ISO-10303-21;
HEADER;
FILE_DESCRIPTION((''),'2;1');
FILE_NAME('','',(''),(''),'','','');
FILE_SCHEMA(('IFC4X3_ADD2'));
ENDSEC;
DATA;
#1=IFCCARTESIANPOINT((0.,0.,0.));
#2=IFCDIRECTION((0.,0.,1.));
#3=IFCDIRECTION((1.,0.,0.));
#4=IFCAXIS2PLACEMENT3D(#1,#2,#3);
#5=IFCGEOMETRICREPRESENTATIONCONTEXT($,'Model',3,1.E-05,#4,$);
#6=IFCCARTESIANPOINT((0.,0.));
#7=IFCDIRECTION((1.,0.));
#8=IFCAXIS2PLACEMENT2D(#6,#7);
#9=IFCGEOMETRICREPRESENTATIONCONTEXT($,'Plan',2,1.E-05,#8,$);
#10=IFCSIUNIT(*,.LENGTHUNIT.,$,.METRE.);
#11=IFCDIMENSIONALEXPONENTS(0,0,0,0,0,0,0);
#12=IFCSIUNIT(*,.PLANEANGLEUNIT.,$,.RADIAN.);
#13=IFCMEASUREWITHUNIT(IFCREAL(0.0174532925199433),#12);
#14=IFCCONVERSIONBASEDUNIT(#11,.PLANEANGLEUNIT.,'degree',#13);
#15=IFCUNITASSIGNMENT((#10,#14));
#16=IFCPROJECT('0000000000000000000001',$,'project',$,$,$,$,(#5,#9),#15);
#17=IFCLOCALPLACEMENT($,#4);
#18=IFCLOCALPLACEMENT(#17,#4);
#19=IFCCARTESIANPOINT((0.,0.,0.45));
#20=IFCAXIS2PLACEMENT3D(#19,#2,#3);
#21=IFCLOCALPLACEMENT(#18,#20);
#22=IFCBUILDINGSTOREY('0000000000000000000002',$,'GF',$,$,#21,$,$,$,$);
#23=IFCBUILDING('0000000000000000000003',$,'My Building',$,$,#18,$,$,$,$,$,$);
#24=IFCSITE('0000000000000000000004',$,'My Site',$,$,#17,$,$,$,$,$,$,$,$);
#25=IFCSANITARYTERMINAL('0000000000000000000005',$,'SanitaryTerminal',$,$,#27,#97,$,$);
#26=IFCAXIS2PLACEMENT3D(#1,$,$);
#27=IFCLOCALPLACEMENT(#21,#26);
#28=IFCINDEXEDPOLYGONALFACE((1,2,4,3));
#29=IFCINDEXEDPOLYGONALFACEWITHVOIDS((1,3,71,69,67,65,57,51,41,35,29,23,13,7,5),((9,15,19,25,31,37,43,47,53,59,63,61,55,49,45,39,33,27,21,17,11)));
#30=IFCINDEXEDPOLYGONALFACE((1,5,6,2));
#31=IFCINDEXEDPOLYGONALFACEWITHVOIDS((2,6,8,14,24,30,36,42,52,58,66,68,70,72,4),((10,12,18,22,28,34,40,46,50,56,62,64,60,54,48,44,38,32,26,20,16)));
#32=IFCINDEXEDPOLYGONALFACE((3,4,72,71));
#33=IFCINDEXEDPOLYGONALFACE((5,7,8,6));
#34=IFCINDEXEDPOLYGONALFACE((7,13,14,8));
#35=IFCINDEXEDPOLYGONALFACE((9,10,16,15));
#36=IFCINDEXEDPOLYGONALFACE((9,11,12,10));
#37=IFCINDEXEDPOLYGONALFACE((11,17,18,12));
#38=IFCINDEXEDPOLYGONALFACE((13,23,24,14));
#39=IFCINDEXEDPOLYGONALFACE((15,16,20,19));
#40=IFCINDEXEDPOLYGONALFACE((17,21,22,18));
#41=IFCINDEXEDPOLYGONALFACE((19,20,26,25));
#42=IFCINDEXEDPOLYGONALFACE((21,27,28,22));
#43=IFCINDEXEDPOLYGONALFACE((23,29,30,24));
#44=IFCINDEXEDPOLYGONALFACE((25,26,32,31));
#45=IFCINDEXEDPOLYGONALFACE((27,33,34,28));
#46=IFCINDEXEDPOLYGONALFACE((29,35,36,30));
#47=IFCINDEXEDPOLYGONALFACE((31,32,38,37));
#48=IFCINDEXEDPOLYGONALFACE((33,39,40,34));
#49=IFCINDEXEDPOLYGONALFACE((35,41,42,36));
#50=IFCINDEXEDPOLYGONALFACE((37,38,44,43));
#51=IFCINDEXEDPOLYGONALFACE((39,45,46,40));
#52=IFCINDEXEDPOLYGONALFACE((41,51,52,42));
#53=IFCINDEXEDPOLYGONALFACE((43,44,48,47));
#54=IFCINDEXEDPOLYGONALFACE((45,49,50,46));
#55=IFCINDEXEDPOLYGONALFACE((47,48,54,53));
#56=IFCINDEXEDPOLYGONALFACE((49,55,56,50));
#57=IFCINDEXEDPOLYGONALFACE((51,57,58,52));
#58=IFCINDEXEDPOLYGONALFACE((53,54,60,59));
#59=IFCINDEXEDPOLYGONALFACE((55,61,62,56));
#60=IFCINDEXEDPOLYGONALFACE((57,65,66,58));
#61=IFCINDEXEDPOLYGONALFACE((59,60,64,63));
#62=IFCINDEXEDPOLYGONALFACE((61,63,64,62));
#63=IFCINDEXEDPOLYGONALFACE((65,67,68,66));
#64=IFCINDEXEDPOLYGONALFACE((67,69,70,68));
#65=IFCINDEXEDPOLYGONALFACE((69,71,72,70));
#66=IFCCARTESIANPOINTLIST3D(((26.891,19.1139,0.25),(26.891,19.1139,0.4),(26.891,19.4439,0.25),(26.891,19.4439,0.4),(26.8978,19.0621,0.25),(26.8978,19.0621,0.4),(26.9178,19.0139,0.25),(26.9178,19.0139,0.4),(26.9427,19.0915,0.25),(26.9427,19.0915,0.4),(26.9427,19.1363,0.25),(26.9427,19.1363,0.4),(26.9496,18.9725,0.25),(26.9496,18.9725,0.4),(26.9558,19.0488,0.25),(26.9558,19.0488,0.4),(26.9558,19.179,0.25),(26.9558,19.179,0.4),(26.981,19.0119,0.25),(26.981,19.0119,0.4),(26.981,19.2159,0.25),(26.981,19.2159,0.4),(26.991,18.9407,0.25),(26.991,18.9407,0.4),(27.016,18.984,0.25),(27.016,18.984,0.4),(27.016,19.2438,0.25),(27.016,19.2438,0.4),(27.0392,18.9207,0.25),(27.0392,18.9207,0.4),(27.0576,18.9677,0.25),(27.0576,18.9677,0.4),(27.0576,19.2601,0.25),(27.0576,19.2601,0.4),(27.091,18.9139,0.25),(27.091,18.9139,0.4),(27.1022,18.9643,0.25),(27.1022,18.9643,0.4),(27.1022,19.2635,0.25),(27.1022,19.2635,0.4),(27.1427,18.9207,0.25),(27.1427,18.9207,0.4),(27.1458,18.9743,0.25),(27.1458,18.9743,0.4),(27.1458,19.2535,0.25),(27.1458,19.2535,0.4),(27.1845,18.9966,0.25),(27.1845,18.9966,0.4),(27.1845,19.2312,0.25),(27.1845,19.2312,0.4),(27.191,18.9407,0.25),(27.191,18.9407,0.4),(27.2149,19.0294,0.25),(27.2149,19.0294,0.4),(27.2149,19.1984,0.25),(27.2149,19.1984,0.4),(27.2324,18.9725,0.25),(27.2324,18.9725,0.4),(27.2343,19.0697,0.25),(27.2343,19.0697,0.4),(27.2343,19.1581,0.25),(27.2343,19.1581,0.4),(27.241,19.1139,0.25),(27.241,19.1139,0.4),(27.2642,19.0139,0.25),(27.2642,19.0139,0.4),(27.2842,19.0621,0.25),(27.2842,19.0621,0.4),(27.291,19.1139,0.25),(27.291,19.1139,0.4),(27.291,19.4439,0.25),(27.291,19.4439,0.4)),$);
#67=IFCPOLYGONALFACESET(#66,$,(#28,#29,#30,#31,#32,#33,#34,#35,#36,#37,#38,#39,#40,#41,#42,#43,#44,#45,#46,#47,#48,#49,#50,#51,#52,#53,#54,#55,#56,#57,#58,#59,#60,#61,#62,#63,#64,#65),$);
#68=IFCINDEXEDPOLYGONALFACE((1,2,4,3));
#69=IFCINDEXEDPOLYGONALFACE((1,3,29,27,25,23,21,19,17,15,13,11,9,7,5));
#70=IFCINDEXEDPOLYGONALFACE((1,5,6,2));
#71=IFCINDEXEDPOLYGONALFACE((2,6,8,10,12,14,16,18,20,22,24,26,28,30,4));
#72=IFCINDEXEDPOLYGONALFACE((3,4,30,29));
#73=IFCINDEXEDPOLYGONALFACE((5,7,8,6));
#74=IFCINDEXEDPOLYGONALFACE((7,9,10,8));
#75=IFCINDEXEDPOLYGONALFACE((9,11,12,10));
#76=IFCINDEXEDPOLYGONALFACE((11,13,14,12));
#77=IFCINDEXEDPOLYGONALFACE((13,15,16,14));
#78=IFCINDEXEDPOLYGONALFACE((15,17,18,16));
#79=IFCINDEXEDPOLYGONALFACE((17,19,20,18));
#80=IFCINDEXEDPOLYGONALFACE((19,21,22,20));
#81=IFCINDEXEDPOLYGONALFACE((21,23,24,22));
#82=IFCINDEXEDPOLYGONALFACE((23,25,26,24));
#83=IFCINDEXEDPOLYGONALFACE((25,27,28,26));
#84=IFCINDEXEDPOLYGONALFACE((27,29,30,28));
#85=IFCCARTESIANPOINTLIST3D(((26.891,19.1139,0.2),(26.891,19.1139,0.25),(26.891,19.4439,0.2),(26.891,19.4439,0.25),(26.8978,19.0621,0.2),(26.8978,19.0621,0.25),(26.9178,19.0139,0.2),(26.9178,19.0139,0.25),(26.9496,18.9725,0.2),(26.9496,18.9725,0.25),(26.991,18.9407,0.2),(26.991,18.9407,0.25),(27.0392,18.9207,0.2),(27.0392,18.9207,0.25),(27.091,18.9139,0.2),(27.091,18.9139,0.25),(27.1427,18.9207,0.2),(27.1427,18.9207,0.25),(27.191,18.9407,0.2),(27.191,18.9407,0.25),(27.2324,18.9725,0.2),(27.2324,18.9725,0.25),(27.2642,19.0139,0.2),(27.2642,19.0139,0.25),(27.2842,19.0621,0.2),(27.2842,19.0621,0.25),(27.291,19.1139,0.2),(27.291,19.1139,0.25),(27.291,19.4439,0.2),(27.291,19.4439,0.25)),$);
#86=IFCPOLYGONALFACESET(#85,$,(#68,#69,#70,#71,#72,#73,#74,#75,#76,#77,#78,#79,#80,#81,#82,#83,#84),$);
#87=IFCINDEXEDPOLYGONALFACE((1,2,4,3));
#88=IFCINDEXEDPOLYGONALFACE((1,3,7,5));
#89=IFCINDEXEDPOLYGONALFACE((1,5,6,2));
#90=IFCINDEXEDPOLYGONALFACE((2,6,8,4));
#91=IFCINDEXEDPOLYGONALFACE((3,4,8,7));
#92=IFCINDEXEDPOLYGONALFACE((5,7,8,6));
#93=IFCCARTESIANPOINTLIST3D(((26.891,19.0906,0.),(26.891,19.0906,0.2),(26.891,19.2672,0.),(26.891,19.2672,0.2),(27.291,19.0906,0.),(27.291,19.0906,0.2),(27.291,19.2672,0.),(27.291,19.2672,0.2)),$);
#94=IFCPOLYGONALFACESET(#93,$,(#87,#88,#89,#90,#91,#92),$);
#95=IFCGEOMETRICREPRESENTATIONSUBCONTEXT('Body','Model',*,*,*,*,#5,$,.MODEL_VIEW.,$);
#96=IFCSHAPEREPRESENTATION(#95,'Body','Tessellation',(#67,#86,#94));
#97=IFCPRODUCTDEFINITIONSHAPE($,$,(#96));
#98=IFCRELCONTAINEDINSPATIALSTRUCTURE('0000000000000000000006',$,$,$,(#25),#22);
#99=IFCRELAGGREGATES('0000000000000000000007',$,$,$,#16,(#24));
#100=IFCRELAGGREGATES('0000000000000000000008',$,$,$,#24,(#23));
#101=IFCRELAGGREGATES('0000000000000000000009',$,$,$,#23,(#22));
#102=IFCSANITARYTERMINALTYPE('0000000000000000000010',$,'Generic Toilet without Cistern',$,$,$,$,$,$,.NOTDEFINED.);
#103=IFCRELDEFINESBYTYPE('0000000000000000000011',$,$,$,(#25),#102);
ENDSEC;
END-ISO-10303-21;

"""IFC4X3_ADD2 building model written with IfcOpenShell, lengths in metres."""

from ifc_helpers import new_model, entity, si_unit, converted_unit, frame, frame_2d, origin_with_axes, origin_2d_with_axis, place, context, subcontext, project, spatial, line, arc, indexed_curve, circle_curve, outline, extrude, shape, source, transform, mapped, type_object, type_shapes, element, save


model = new_model("IFC4X3_ADD2")

# Units and contexts
model_context = context("Model", 3, precision=1e-05, world=origin_with_axes())
plan_context = context("Plan", 2, precision=1e-05, world=origin_2d_with_axis())
body_context_1 = subcontext(model_context, "Body", "Model", "MODEL_VIEW")
body_context_2 = subcontext(plan_context, "Body", "Plan", "PLAN_VIEW")
ifc_project = project(units=[si_unit("LENGTHUNIT", "METRE"), converted_unit("PLANEANGLEUNIT", "degree", entity("IfcReal", 0.0174532925199433), si_unit("PLANEANGLEUNIT", "RADIAN"), dimensions=[0, 0, 0, 0, 0, 0, 0])], contexts=[model_context, plan_context])

# Site, building, storey
site_placement = place(None, origin_with_axes())
site = spatial("IfcSite", under=ifc_project, at=site_placement, Name="My Site")
building_placement = place(site_placement, origin_with_axes())
building = spatial("IfcBuilding", under=site, at=building_placement, Name="My Building")
storey_placement = place(building_placement, frame((0.0, 0.0, 0.45), z_axis=(0.0, 0.0, 1.0), x_axis=(1.0, 0.0, 0.0)))
storey = spatial("IfcBuildingStorey", under=building, at=storey_placement, Name="GF")

# Sanitary terminal
sanitary_terminal_type_1 = type_object("IfcSanitaryTerminalType", Name="Generic Toilet without Cistern", PredefinedType="NOTDEFINED")
shared_shape_1 = source(origin_with_axes(), body_context_1, "Body", "SweptSolid", [
    extrude(outline(indexed_curve([(-0.2, 0.0), (0.2, 0.0), (0.2, -0.33), (0.1414, -0.4714), (0.0, -0.53), (-0.1414, -0.4714), (-0.2, -0.33)], segments=[line(1, 2), line(2, 3), arc(3, 4, 5), arc(5, 6, 7), line(7, 1)]), holes=[circle_curve(frame_2d((0.0, -0.33)), 0.15)]), frame((0.0, 0.0, 0.25), z_axis=(0.0, 0.0, 1.0), x_axis=(1.0, 0.0, 0.0)), (0.0, 0.0, 1.0), 0.15),
    extrude(outline(indexed_curve([(-0.2, 0.0), (0.2, 0.0), (0.2, -0.33), (0.1414, -0.4714), (0.0, -0.53), (-0.1414, -0.4714), (-0.2, -0.33)], segments=[line(1, 2), line(2, 3), arc(3, 4, 5), arc(5, 6, 7), line(7, 1)])), frame((0.0, 0.0, 0.2), z_axis=(0.0, 0.0, 1.0), x_axis=(1.0, 0.0, 0.0)), (0.0, 0.0, 1.0), 0.05),
    extrude(outline(indexed_curve([(-0.2, -0.1767), (0.2, -0.1767), (0.2, -0.3533), (-0.2, -0.3533)], segments=[line(1, 2, 3, 4, 1)])), origin_with_axes(), (0.0, 0.0, 1.0), 0.2),
])
shared_shape_2 = source(origin_with_axes(), body_context_2, "Body", "Annotation2D", [
    entity("IfcGeometricCurveSet", [entity("IfcIndexedPolyCurve", entity("IfcCartesianPointList2D", [[-0.1068, -0.124], [-0.0957, -0.1129], [-0.0804, -0.1088], [0.0804, -0.1088], [0.0957, -0.1129], [0.1068, -0.124], [0.1109, -0.1393], [0.1109, -0.3476], [0.1025, -0.3926], [0.0784, -0.4308], [0.0424, -0.4563], [0.0, -0.4652], [-0.0424, -0.4563], [-0.0784, -0.4308], [-0.1025, -0.3926], [-0.1109, -0.3476], [-0.1109, -0.1393]]), [entity("IfcLineIndex", [1, 2, 3, 4, 5, 6, 7, 8, 9, 10, 11, 12, 13, 14, 15, 16, 17, 1])]), entity("IfcIndexedPolyCurve", entity("IfcCartesianPointList2D", [[-0.1962, -0.2314], [-0.1848, -0.301], [-0.1764, -0.3339], [-0.1663, -0.3651], [-0.1546, -0.3944], [-0.1414, -0.4213], [-0.1269, -0.4458], [-0.1111, -0.4675], [-0.0943, -0.4862], [-0.0765, -0.5018], [-0.0581, -0.514], [-0.039, -0.5229], [-0.0196, -0.5282], [0.0, -0.53], [0.0196, -0.5282], [0.039, -0.5229], [0.0581, -0.514], [0.0765, -0.5018], [0.0943, -0.4862], [0.1111, -0.4675], [0.1269, -0.4458], [0.1414, -0.4213], [0.1546, -0.3944], [0.1663, -0.3651], [0.1764, -0.3339], [0.1848, -0.301], [0.1962, -0.2314], [0.2, -0.159], [0.1872, 0.0], [-0.1872, 0.0], [-0.2, -0.159]]), [entity("IfcLineIndex", [1, 2, 3, 4, 5, 6, 7, 8, 9, 10, 11, 12, 13, 14, 15, 16, 17, 18, 19, 20, 21, 22, 23, 24, 25, 26, 27, 28, 29, 30, 31, 1])])]),
])
type_shapes(sanitary_terminal_type_1, [shared_shape_1, shared_shape_2])
sanitary_terminal_1_placement = place(storey_placement, frame((27.091, 19.4439, 0.0), z_axis=(0.0, 0.0, 1.0), x_axis=(1.0, 0.0, 0.0)))
element("IfcSanitaryTerminal", 1, at=sanitary_terminal_1_placement, inside=storey, type_object=sanitary_terminal_type_1, Name="SanitaryTerminal", shapes=[
    shape(body_context_1, "Body", "MappedRepresentation", [mapped(shared_shape_1, transform((0.0, 0.0, 0.0), x_axis=(1.0, 0.0, 0.0), y_axis=(0.0, 1.0, 0.0), z_axis=(0.0, 0.0, 1.0), scale=1.0))]),
    shape(body_context_2, "Body", "MappedRepresentation", [mapped(shared_shape_2, transform((0.0, 0.0, 0.0), x_axis=(1.0, 0.0, 0.0), y_axis=(0.0, 1.0, 0.0), z_axis=(0.0, 0.0, 1.0), scale=1.0))]),
])

save(model, "model.ifc")
